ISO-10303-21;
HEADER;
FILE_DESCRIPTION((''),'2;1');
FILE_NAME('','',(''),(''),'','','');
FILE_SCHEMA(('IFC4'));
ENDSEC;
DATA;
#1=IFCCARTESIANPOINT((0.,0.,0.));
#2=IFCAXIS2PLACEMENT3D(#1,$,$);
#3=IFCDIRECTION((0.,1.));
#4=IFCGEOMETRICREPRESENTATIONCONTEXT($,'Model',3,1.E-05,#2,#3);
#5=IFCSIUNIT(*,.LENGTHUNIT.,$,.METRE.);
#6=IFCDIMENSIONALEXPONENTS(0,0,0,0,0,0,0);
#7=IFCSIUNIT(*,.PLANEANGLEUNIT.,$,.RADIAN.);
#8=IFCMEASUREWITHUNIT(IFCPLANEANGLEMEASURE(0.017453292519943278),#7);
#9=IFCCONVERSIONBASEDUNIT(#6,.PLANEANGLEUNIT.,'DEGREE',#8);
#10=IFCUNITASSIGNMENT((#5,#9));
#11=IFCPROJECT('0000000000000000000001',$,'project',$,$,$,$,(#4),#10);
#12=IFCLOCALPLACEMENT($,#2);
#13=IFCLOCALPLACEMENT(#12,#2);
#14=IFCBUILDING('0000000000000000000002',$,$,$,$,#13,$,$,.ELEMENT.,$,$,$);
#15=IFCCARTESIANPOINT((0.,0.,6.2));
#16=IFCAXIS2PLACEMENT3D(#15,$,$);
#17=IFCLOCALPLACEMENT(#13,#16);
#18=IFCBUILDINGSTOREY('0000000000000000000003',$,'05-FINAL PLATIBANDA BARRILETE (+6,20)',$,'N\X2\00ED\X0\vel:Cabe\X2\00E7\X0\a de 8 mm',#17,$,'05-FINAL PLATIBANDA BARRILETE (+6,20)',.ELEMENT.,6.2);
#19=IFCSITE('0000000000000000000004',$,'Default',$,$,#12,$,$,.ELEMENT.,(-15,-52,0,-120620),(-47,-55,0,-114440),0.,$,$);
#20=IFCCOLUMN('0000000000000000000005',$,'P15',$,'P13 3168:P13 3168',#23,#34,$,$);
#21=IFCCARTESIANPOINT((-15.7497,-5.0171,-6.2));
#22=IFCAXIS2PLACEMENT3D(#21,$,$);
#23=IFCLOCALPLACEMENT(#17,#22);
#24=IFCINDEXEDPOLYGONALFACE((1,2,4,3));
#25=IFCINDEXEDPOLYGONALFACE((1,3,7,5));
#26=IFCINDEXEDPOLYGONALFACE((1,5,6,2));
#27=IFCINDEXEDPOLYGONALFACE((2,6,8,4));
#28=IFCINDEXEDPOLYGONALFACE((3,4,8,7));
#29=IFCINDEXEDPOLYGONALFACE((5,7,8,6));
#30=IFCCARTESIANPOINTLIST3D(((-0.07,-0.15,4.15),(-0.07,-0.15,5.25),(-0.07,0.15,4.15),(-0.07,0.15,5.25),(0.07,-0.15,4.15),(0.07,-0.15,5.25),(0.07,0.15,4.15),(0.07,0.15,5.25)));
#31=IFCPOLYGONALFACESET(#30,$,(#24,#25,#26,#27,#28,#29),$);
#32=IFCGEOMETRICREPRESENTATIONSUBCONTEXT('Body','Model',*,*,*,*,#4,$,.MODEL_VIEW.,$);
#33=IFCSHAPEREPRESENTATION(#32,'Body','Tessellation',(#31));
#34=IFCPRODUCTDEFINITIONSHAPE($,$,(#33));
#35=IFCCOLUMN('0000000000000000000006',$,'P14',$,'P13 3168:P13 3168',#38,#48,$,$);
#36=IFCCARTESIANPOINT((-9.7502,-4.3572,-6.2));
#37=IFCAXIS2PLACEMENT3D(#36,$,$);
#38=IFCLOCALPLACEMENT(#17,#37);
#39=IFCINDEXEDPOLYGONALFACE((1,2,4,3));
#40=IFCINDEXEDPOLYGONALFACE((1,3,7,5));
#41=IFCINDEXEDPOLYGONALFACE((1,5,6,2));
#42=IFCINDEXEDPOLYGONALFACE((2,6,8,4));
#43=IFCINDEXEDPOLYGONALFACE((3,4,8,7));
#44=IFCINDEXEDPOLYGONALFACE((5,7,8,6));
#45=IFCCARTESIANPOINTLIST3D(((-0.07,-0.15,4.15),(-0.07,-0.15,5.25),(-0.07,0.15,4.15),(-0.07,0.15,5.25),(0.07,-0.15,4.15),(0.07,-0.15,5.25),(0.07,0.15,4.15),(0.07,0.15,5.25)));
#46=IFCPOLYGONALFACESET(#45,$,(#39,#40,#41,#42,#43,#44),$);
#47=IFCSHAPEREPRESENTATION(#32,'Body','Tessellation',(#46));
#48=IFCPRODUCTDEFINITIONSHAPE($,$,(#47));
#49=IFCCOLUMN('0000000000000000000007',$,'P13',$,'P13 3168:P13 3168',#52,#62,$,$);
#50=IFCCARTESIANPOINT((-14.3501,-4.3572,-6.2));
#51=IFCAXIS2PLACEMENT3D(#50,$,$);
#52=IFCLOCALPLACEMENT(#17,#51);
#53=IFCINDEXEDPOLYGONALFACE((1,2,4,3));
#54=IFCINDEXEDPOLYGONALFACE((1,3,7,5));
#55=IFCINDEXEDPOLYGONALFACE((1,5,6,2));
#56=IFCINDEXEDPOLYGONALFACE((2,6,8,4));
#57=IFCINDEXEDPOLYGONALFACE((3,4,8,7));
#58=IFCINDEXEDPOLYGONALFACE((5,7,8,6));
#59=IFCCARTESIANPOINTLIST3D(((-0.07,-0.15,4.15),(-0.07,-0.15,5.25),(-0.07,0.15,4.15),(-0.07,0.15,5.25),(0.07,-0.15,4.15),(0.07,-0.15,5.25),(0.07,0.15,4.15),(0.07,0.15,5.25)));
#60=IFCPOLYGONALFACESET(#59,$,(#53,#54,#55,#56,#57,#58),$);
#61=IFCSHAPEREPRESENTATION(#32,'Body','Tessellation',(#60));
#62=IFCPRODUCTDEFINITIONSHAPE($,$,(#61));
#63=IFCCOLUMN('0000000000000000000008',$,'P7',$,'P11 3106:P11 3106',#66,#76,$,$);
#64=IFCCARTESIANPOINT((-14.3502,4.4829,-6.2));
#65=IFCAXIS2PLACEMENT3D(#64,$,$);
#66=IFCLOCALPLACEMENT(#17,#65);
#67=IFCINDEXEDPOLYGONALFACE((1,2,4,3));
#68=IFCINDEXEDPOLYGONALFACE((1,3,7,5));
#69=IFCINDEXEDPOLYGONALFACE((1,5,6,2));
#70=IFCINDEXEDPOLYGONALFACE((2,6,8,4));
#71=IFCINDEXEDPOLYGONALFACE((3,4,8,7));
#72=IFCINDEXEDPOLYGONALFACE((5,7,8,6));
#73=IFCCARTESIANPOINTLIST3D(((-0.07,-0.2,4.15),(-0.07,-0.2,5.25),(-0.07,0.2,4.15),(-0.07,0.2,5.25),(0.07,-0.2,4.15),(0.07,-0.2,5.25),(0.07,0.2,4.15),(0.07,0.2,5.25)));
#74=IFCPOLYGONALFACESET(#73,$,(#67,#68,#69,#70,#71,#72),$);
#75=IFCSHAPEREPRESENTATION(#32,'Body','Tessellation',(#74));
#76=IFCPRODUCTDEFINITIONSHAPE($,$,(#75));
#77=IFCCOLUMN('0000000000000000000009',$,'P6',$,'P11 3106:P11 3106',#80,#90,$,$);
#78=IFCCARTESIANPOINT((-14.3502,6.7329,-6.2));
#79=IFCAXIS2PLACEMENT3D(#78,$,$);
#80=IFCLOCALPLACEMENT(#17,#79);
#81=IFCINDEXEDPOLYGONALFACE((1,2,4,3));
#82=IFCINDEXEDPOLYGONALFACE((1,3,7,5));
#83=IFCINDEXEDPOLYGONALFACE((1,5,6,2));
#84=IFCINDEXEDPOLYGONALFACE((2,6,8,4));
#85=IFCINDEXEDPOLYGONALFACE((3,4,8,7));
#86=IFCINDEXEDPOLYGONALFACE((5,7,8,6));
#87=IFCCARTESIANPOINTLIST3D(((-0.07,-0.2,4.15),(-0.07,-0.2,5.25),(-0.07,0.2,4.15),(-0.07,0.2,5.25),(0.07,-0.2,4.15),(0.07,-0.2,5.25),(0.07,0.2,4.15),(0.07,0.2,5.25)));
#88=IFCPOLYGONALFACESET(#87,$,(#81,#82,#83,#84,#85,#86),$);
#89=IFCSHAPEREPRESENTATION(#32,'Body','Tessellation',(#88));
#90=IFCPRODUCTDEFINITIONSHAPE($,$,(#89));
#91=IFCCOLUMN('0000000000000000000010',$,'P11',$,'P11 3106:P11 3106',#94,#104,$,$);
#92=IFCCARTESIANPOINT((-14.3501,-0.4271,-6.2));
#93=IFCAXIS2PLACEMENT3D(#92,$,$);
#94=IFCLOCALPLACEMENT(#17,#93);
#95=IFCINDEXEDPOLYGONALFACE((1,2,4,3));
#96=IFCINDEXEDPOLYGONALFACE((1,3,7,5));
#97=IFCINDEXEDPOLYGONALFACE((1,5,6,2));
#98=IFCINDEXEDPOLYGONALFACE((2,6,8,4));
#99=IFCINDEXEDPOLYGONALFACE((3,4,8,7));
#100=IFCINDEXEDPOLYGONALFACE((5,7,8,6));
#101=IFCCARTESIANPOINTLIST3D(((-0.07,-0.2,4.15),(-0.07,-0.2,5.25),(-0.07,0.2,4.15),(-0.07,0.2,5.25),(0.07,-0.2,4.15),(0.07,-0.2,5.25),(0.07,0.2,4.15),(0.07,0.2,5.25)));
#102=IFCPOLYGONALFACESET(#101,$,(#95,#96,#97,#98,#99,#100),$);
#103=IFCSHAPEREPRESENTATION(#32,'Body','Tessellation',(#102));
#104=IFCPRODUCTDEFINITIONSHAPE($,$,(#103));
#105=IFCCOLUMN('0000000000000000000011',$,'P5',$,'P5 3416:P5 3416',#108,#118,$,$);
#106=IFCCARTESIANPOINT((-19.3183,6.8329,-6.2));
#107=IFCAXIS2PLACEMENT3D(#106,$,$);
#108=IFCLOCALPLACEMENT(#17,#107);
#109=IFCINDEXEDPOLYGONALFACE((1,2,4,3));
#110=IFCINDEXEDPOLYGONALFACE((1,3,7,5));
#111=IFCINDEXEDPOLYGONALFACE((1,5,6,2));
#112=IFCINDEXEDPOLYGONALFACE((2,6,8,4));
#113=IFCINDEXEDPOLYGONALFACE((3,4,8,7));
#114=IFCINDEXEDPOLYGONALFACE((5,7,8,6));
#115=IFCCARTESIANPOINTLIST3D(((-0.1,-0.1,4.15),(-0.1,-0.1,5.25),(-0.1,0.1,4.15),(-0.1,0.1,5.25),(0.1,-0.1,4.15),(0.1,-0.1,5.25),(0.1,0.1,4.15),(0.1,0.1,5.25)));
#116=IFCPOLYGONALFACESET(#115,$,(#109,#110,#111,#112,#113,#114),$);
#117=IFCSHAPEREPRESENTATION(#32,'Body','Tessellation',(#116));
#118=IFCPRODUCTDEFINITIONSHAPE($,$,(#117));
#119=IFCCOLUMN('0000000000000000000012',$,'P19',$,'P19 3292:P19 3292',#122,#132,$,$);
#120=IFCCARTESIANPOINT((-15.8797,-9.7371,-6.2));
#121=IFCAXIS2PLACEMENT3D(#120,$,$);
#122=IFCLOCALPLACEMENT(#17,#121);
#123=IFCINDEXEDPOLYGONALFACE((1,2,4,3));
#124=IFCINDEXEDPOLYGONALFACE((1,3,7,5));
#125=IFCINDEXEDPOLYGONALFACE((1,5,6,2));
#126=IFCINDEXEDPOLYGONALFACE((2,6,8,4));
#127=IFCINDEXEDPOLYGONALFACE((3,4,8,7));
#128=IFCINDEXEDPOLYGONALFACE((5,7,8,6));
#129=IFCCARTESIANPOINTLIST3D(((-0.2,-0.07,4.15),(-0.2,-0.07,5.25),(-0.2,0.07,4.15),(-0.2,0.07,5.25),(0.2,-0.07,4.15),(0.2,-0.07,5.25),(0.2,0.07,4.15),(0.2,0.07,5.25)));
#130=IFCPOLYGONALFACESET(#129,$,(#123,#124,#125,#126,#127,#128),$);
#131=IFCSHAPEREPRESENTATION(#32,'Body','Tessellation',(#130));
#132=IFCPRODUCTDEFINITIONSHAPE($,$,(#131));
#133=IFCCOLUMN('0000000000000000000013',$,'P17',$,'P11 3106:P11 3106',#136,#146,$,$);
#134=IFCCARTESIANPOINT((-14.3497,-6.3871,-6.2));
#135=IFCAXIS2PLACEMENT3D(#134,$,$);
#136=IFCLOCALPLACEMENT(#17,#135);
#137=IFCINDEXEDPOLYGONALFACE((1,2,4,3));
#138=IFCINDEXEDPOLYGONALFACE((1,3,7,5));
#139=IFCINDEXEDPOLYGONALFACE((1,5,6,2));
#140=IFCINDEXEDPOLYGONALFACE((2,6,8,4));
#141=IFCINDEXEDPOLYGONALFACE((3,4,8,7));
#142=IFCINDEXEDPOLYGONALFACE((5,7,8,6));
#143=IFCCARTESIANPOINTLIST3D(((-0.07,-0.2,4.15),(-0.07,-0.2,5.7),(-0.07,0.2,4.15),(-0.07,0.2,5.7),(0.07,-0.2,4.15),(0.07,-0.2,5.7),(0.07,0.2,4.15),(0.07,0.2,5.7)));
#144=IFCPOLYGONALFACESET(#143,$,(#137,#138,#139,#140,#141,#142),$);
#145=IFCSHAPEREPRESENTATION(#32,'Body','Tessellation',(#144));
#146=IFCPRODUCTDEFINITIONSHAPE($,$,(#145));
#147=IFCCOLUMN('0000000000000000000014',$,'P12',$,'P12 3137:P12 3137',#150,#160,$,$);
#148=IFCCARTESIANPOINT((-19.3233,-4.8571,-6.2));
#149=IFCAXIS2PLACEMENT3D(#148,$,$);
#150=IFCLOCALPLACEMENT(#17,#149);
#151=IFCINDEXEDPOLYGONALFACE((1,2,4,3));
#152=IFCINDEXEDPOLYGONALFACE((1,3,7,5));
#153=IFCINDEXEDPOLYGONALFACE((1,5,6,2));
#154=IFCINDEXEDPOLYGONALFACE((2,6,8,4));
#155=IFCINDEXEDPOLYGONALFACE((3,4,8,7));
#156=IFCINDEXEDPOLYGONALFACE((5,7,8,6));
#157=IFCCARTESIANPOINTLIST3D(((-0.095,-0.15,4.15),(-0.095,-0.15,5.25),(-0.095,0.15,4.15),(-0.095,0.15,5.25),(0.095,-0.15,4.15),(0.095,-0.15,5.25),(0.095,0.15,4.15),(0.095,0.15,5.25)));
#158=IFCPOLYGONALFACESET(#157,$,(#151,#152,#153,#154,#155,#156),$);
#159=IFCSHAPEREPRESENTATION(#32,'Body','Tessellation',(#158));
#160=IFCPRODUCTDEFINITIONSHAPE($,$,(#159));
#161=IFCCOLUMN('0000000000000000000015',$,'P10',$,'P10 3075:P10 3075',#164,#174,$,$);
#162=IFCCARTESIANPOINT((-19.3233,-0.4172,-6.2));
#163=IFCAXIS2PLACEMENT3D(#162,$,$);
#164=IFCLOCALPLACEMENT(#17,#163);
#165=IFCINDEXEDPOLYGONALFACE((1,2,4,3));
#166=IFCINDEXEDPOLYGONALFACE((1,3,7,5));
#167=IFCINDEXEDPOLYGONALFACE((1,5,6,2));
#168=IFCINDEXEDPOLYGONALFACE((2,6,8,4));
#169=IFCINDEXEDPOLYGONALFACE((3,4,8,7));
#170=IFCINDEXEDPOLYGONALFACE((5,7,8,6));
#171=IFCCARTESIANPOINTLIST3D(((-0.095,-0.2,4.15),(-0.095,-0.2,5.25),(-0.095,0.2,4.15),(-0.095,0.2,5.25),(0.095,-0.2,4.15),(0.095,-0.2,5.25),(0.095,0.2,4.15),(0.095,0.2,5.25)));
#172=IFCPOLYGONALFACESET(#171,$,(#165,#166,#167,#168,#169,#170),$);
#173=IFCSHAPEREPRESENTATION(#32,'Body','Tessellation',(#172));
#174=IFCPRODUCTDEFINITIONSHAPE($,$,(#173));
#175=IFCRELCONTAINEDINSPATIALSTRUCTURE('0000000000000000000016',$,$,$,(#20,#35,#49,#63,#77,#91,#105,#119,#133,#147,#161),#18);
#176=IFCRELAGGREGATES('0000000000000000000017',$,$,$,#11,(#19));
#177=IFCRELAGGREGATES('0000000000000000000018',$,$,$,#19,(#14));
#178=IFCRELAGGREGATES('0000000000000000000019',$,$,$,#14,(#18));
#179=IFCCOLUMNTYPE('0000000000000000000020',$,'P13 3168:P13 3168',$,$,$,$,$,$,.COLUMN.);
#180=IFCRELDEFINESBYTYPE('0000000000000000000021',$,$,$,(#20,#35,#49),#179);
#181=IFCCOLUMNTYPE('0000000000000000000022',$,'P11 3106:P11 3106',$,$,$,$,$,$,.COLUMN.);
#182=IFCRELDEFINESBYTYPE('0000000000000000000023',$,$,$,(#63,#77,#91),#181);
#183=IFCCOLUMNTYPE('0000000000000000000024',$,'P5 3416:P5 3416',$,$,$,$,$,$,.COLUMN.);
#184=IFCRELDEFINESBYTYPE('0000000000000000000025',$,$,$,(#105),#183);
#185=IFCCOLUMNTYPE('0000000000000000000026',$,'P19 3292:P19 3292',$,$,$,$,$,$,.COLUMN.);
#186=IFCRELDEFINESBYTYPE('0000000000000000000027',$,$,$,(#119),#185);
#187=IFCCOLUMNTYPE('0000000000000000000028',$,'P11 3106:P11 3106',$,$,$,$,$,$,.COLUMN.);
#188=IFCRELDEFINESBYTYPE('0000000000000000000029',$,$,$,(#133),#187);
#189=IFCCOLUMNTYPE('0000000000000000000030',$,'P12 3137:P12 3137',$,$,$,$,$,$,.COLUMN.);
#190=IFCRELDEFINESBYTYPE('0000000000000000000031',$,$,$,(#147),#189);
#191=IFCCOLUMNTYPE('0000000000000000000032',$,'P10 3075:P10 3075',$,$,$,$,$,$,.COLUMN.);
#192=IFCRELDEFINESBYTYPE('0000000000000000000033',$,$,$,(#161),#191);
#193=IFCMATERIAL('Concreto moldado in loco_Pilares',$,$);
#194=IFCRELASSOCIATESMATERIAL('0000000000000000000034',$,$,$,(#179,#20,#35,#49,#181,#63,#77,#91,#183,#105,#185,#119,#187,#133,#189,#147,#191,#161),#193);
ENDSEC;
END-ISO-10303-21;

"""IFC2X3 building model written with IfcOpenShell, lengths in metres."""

from ifc_helpers import new_model, entity, si_unit, converted_unit, direction, frame, origin, origin_2d_with_axis, place, context, subcontext, project, spatial, rectangle, extrude, source, transform, mapped, material, type_object, type_shapes, element, save


model = new_model("IFC2X3")

# Units and contexts
model_context = context("Model", 3, precision=1e-05, world=origin(), true_north=direction((0.0, 1.0)))
body_context = subcontext(model_context, "Body", "Model", "MODEL_VIEW")
ifc_project = project(units=[si_unit("LENGTHUNIT", "METRE"), converted_unit("PLANEANGLEUNIT", "DEGREE", entity("IfcPlaneAngleMeasure", 0.017453292519943278), si_unit("PLANEANGLEUNIT", "RADIAN"), dimensions=[0, 0, 0, 0, 0, 0, 0])], contexts=[model_context])

# Site, building, storey
site_placement = place(None, origin())
site = spatial("IfcSite", under=ifc_project, at=site_placement, Name="Default", CompositionType="ELEMENT", RefLatitude=(-15, -52, 0, -120620), RefLongitude=(-47, -55, 0, -114440), RefElevation=0.0)
building_placement = place(site_placement, origin())
building = spatial("IfcBuilding", under=site, at=building_placement, CompositionType="ELEMENT")
storey_placement = place(building_placement, frame((0.0, 0.0, 6.2)))
storey = spatial("IfcBuildingStorey", under=building, at=storey_placement, Name="05-FINAL PLATIBANDA BARRILETE (+6,20)", ObjectType="Nível:Cabeça de 8 mm", LongName="05-FINAL PLATIBANDA BARRILETE (+6,20)", CompositionType="ELEMENT", Elevation=6.2)

# Columns
ifc_material_1 = material(Name="Concreto moldado in loco_Pilares")
column_type_1 = type_object("IfcColumnType", Name="P13 3168:P13 3168", PredefinedType="COLUMN", material=ifc_material_1)
shared_shape_1 = source(origin(), body_context, "Body", "SweptSolid", [
    extrude(rectangle(XDim=0.3, YDim=0.14, at=origin_2d_with_axis()), frame((0.0, 0.0, 4.15), z_axis=(0.0, 0.0, 1.0), x_axis=(0.0, -1.0, 0.0)), (0.0, 0.0, 1.0), 1.1),
])
type_shapes(column_type_1, [shared_shape_1])
for number, where, name in (
    (1, (-15.7497, -5.0171, -6.2), "P15"),
    (2, (-9.7502, -4.3572, -6.2), "P14"),
    (3, (-14.3501, -4.3572, -6.2), "P13"),
):
    element("IfcColumn", number, at=place(storey_placement, frame(where)), inside=storey, type_object=column_type_1, material=ifc_material_1, Name=name, ObjectType="P13 3168:P13 3168", context=body_context, shape_type="MappedRepresentation", body=[
        mapped(shared_shape_1, transform((0.0, 0.0, 0.0), scale=1.0)),
    ])
column_type_2 = type_object("IfcColumnType", Name="P11 3106:P11 3106", PredefinedType="COLUMN", material=ifc_material_1)
shared_shape_2 = source(origin(), body_context, "Body", "SweptSolid", [
    extrude(rectangle(XDim=0.4, YDim=0.14, at=origin_2d_with_axis()), frame((0.0, 0.0, 4.15), z_axis=(0.0, 0.0, 1.0), x_axis=(0.0, -1.0, 0.0)), (0.0, 0.0, 1.0), 1.1),
])
type_shapes(column_type_2, [shared_shape_2])
for number, where, name in (
    (4, (-14.3502, 4.4829, -6.2), "P7"),
    (5, (-14.3502, 6.7329, -6.2), "P6"),
    (6, (-14.3501, -0.4271, -6.2), "P11"),
):
    element("IfcColumn", number, at=place(storey_placement, frame(where)), inside=storey, type_object=column_type_2, material=ifc_material_1, Name=name, ObjectType="P11 3106:P11 3106", context=body_context, shape_type="MappedRepresentation", body=[
        mapped(shared_shape_2, transform((0.0, 0.0, 0.0), scale=1.0)),
    ])
column_type_3 = type_object("IfcColumnType", Name="P5 3416:P5 3416", PredefinedType="COLUMN", material=ifc_material_1)
shared_shape_3 = source(origin(), body_context, "Body", "SweptSolid", [
    extrude(rectangle(XDim=0.2, YDim=0.2, at=origin_2d_with_axis()), frame((0.0, 0.0, 4.15), z_axis=(0.0, 0.0, 1.0), x_axis=(0.0, -1.0, 0.0)), (0.0, 0.0, 1.0), 1.1),
])
type_shapes(column_type_3, [shared_shape_3])
column_1_placement = place(storey_placement, frame((-19.3183, 6.8329, -6.2)))
element("IfcColumn", 7, at=column_1_placement, inside=storey, type_object=column_type_3, material=ifc_material_1, Name="P5", ObjectType="P5 3416:P5 3416", context=body_context, shape_type="MappedRepresentation", body=[
    mapped(shared_shape_3, transform((0.0, 0.0, 0.0), scale=1.0)),
])
column_type_4 = type_object("IfcColumnType", Name="P19 3292:P19 3292", PredefinedType="COLUMN", material=ifc_material_1)
shared_shape_4 = source(origin(), body_context, "Body", "SweptSolid", [
    extrude(rectangle(XDim=0.4, YDim=0.14, at=origin_2d_with_axis()), frame((0.0, 0.0, 4.15)), (0.0, 0.0, 1.0), 1.1),
])
type_shapes(column_type_4, [shared_shape_4])
column_2_placement = place(storey_placement, frame((-15.8797, -9.7371, -6.2)))
element("IfcColumn", 8, at=column_2_placement, inside=storey, type_object=column_type_4, material=ifc_material_1, Name="P19", ObjectType="P19 3292:P19 3292", context=body_context, shape_type="MappedRepresentation", body=[
    mapped(shared_shape_4, transform((0.0, 0.0, 0.0), scale=1.0)),
])
column_type_5 = type_object("IfcColumnType", Name="P11 3106:P11 3106", PredefinedType="COLUMN", material=ifc_material_1)
shared_shape_5 = source(origin(), body_context, "Body", "SweptSolid", [
    extrude(rectangle(XDim=0.4, YDim=0.14, at=origin_2d_with_axis()), frame((0.0, 0.0, 4.15), z_axis=(0.0, 0.0, 1.0), x_axis=(0.0, -1.0, 0.0)), (0.0, 0.0, 1.0), 1.55),
])
type_shapes(column_type_5, [shared_shape_5])
column_3_placement = place(storey_placement, frame((-14.3497, -6.3871, -6.2)))
element("IfcColumn", 9, at=column_3_placement, inside=storey, type_object=column_type_5, material=ifc_material_1, Name="P17", ObjectType="P11 3106:P11 3106", context=body_context, shape_type="MappedRepresentation", body=[
    mapped(shared_shape_5, transform((0.0, 0.0, 0.0), scale=1.0)),
])
column_type_6 = type_object("IfcColumnType", Name="P12 3137:P12 3137", PredefinedType="COLUMN", material=ifc_material_1)
shared_shape_6 = source(origin(), body_context, "Body", "SweptSolid", [
    extrude(rectangle(XDim=0.3, YDim=0.19, at=origin_2d_with_axis()), frame((0.0, 0.0, 4.15), z_axis=(0.0, 0.0, 1.0), x_axis=(0.0, -1.0, 0.0)), (0.0, 0.0, 1.0), 1.1),
])
type_shapes(column_type_6, [shared_shape_6])
column_4_placement = place(storey_placement, frame((-19.3233, -4.8571, -6.2)))
element("IfcColumn", 10, at=column_4_placement, inside=storey, type_object=column_type_6, material=ifc_material_1, Name="P12", ObjectType="P12 3137:P12 3137", context=body_context, shape_type="MappedRepresentation", body=[
    mapped(shared_shape_6, transform((0.0, 0.0, 0.0), scale=1.0)),
])
column_type_7 = type_object("IfcColumnType", Name="P10 3075:P10 3075", PredefinedType="COLUMN", material=ifc_material_1)
shared_shape_7 = source(origin(), body_context, "Body", "SweptSolid", [
    extrude(rectangle(XDim=0.4, YDim=0.19, at=origin_2d_with_axis()), frame((0.0, 0.0, 4.15), z_axis=(0.0, 0.0, 1.0), x_axis=(0.0, -1.0, 0.0)), (0.0, 0.0, 1.0), 1.1),
])
type_shapes(column_type_7, [shared_shape_7])
column_5_placement = place(storey_placement, frame((-19.3233, -0.4172, -6.2)))
element("IfcColumn", 11, at=column_5_placement, inside=storey, type_object=column_type_7, material=ifc_material_1, Name="P10", ObjectType="P10 3075:P10 3075", context=body_context, shape_type="MappedRepresentation", body=[
    mapped(shared_shape_7, transform((0.0, 0.0, 0.0), scale=1.0)),
])

save(model, "model.ifc")
